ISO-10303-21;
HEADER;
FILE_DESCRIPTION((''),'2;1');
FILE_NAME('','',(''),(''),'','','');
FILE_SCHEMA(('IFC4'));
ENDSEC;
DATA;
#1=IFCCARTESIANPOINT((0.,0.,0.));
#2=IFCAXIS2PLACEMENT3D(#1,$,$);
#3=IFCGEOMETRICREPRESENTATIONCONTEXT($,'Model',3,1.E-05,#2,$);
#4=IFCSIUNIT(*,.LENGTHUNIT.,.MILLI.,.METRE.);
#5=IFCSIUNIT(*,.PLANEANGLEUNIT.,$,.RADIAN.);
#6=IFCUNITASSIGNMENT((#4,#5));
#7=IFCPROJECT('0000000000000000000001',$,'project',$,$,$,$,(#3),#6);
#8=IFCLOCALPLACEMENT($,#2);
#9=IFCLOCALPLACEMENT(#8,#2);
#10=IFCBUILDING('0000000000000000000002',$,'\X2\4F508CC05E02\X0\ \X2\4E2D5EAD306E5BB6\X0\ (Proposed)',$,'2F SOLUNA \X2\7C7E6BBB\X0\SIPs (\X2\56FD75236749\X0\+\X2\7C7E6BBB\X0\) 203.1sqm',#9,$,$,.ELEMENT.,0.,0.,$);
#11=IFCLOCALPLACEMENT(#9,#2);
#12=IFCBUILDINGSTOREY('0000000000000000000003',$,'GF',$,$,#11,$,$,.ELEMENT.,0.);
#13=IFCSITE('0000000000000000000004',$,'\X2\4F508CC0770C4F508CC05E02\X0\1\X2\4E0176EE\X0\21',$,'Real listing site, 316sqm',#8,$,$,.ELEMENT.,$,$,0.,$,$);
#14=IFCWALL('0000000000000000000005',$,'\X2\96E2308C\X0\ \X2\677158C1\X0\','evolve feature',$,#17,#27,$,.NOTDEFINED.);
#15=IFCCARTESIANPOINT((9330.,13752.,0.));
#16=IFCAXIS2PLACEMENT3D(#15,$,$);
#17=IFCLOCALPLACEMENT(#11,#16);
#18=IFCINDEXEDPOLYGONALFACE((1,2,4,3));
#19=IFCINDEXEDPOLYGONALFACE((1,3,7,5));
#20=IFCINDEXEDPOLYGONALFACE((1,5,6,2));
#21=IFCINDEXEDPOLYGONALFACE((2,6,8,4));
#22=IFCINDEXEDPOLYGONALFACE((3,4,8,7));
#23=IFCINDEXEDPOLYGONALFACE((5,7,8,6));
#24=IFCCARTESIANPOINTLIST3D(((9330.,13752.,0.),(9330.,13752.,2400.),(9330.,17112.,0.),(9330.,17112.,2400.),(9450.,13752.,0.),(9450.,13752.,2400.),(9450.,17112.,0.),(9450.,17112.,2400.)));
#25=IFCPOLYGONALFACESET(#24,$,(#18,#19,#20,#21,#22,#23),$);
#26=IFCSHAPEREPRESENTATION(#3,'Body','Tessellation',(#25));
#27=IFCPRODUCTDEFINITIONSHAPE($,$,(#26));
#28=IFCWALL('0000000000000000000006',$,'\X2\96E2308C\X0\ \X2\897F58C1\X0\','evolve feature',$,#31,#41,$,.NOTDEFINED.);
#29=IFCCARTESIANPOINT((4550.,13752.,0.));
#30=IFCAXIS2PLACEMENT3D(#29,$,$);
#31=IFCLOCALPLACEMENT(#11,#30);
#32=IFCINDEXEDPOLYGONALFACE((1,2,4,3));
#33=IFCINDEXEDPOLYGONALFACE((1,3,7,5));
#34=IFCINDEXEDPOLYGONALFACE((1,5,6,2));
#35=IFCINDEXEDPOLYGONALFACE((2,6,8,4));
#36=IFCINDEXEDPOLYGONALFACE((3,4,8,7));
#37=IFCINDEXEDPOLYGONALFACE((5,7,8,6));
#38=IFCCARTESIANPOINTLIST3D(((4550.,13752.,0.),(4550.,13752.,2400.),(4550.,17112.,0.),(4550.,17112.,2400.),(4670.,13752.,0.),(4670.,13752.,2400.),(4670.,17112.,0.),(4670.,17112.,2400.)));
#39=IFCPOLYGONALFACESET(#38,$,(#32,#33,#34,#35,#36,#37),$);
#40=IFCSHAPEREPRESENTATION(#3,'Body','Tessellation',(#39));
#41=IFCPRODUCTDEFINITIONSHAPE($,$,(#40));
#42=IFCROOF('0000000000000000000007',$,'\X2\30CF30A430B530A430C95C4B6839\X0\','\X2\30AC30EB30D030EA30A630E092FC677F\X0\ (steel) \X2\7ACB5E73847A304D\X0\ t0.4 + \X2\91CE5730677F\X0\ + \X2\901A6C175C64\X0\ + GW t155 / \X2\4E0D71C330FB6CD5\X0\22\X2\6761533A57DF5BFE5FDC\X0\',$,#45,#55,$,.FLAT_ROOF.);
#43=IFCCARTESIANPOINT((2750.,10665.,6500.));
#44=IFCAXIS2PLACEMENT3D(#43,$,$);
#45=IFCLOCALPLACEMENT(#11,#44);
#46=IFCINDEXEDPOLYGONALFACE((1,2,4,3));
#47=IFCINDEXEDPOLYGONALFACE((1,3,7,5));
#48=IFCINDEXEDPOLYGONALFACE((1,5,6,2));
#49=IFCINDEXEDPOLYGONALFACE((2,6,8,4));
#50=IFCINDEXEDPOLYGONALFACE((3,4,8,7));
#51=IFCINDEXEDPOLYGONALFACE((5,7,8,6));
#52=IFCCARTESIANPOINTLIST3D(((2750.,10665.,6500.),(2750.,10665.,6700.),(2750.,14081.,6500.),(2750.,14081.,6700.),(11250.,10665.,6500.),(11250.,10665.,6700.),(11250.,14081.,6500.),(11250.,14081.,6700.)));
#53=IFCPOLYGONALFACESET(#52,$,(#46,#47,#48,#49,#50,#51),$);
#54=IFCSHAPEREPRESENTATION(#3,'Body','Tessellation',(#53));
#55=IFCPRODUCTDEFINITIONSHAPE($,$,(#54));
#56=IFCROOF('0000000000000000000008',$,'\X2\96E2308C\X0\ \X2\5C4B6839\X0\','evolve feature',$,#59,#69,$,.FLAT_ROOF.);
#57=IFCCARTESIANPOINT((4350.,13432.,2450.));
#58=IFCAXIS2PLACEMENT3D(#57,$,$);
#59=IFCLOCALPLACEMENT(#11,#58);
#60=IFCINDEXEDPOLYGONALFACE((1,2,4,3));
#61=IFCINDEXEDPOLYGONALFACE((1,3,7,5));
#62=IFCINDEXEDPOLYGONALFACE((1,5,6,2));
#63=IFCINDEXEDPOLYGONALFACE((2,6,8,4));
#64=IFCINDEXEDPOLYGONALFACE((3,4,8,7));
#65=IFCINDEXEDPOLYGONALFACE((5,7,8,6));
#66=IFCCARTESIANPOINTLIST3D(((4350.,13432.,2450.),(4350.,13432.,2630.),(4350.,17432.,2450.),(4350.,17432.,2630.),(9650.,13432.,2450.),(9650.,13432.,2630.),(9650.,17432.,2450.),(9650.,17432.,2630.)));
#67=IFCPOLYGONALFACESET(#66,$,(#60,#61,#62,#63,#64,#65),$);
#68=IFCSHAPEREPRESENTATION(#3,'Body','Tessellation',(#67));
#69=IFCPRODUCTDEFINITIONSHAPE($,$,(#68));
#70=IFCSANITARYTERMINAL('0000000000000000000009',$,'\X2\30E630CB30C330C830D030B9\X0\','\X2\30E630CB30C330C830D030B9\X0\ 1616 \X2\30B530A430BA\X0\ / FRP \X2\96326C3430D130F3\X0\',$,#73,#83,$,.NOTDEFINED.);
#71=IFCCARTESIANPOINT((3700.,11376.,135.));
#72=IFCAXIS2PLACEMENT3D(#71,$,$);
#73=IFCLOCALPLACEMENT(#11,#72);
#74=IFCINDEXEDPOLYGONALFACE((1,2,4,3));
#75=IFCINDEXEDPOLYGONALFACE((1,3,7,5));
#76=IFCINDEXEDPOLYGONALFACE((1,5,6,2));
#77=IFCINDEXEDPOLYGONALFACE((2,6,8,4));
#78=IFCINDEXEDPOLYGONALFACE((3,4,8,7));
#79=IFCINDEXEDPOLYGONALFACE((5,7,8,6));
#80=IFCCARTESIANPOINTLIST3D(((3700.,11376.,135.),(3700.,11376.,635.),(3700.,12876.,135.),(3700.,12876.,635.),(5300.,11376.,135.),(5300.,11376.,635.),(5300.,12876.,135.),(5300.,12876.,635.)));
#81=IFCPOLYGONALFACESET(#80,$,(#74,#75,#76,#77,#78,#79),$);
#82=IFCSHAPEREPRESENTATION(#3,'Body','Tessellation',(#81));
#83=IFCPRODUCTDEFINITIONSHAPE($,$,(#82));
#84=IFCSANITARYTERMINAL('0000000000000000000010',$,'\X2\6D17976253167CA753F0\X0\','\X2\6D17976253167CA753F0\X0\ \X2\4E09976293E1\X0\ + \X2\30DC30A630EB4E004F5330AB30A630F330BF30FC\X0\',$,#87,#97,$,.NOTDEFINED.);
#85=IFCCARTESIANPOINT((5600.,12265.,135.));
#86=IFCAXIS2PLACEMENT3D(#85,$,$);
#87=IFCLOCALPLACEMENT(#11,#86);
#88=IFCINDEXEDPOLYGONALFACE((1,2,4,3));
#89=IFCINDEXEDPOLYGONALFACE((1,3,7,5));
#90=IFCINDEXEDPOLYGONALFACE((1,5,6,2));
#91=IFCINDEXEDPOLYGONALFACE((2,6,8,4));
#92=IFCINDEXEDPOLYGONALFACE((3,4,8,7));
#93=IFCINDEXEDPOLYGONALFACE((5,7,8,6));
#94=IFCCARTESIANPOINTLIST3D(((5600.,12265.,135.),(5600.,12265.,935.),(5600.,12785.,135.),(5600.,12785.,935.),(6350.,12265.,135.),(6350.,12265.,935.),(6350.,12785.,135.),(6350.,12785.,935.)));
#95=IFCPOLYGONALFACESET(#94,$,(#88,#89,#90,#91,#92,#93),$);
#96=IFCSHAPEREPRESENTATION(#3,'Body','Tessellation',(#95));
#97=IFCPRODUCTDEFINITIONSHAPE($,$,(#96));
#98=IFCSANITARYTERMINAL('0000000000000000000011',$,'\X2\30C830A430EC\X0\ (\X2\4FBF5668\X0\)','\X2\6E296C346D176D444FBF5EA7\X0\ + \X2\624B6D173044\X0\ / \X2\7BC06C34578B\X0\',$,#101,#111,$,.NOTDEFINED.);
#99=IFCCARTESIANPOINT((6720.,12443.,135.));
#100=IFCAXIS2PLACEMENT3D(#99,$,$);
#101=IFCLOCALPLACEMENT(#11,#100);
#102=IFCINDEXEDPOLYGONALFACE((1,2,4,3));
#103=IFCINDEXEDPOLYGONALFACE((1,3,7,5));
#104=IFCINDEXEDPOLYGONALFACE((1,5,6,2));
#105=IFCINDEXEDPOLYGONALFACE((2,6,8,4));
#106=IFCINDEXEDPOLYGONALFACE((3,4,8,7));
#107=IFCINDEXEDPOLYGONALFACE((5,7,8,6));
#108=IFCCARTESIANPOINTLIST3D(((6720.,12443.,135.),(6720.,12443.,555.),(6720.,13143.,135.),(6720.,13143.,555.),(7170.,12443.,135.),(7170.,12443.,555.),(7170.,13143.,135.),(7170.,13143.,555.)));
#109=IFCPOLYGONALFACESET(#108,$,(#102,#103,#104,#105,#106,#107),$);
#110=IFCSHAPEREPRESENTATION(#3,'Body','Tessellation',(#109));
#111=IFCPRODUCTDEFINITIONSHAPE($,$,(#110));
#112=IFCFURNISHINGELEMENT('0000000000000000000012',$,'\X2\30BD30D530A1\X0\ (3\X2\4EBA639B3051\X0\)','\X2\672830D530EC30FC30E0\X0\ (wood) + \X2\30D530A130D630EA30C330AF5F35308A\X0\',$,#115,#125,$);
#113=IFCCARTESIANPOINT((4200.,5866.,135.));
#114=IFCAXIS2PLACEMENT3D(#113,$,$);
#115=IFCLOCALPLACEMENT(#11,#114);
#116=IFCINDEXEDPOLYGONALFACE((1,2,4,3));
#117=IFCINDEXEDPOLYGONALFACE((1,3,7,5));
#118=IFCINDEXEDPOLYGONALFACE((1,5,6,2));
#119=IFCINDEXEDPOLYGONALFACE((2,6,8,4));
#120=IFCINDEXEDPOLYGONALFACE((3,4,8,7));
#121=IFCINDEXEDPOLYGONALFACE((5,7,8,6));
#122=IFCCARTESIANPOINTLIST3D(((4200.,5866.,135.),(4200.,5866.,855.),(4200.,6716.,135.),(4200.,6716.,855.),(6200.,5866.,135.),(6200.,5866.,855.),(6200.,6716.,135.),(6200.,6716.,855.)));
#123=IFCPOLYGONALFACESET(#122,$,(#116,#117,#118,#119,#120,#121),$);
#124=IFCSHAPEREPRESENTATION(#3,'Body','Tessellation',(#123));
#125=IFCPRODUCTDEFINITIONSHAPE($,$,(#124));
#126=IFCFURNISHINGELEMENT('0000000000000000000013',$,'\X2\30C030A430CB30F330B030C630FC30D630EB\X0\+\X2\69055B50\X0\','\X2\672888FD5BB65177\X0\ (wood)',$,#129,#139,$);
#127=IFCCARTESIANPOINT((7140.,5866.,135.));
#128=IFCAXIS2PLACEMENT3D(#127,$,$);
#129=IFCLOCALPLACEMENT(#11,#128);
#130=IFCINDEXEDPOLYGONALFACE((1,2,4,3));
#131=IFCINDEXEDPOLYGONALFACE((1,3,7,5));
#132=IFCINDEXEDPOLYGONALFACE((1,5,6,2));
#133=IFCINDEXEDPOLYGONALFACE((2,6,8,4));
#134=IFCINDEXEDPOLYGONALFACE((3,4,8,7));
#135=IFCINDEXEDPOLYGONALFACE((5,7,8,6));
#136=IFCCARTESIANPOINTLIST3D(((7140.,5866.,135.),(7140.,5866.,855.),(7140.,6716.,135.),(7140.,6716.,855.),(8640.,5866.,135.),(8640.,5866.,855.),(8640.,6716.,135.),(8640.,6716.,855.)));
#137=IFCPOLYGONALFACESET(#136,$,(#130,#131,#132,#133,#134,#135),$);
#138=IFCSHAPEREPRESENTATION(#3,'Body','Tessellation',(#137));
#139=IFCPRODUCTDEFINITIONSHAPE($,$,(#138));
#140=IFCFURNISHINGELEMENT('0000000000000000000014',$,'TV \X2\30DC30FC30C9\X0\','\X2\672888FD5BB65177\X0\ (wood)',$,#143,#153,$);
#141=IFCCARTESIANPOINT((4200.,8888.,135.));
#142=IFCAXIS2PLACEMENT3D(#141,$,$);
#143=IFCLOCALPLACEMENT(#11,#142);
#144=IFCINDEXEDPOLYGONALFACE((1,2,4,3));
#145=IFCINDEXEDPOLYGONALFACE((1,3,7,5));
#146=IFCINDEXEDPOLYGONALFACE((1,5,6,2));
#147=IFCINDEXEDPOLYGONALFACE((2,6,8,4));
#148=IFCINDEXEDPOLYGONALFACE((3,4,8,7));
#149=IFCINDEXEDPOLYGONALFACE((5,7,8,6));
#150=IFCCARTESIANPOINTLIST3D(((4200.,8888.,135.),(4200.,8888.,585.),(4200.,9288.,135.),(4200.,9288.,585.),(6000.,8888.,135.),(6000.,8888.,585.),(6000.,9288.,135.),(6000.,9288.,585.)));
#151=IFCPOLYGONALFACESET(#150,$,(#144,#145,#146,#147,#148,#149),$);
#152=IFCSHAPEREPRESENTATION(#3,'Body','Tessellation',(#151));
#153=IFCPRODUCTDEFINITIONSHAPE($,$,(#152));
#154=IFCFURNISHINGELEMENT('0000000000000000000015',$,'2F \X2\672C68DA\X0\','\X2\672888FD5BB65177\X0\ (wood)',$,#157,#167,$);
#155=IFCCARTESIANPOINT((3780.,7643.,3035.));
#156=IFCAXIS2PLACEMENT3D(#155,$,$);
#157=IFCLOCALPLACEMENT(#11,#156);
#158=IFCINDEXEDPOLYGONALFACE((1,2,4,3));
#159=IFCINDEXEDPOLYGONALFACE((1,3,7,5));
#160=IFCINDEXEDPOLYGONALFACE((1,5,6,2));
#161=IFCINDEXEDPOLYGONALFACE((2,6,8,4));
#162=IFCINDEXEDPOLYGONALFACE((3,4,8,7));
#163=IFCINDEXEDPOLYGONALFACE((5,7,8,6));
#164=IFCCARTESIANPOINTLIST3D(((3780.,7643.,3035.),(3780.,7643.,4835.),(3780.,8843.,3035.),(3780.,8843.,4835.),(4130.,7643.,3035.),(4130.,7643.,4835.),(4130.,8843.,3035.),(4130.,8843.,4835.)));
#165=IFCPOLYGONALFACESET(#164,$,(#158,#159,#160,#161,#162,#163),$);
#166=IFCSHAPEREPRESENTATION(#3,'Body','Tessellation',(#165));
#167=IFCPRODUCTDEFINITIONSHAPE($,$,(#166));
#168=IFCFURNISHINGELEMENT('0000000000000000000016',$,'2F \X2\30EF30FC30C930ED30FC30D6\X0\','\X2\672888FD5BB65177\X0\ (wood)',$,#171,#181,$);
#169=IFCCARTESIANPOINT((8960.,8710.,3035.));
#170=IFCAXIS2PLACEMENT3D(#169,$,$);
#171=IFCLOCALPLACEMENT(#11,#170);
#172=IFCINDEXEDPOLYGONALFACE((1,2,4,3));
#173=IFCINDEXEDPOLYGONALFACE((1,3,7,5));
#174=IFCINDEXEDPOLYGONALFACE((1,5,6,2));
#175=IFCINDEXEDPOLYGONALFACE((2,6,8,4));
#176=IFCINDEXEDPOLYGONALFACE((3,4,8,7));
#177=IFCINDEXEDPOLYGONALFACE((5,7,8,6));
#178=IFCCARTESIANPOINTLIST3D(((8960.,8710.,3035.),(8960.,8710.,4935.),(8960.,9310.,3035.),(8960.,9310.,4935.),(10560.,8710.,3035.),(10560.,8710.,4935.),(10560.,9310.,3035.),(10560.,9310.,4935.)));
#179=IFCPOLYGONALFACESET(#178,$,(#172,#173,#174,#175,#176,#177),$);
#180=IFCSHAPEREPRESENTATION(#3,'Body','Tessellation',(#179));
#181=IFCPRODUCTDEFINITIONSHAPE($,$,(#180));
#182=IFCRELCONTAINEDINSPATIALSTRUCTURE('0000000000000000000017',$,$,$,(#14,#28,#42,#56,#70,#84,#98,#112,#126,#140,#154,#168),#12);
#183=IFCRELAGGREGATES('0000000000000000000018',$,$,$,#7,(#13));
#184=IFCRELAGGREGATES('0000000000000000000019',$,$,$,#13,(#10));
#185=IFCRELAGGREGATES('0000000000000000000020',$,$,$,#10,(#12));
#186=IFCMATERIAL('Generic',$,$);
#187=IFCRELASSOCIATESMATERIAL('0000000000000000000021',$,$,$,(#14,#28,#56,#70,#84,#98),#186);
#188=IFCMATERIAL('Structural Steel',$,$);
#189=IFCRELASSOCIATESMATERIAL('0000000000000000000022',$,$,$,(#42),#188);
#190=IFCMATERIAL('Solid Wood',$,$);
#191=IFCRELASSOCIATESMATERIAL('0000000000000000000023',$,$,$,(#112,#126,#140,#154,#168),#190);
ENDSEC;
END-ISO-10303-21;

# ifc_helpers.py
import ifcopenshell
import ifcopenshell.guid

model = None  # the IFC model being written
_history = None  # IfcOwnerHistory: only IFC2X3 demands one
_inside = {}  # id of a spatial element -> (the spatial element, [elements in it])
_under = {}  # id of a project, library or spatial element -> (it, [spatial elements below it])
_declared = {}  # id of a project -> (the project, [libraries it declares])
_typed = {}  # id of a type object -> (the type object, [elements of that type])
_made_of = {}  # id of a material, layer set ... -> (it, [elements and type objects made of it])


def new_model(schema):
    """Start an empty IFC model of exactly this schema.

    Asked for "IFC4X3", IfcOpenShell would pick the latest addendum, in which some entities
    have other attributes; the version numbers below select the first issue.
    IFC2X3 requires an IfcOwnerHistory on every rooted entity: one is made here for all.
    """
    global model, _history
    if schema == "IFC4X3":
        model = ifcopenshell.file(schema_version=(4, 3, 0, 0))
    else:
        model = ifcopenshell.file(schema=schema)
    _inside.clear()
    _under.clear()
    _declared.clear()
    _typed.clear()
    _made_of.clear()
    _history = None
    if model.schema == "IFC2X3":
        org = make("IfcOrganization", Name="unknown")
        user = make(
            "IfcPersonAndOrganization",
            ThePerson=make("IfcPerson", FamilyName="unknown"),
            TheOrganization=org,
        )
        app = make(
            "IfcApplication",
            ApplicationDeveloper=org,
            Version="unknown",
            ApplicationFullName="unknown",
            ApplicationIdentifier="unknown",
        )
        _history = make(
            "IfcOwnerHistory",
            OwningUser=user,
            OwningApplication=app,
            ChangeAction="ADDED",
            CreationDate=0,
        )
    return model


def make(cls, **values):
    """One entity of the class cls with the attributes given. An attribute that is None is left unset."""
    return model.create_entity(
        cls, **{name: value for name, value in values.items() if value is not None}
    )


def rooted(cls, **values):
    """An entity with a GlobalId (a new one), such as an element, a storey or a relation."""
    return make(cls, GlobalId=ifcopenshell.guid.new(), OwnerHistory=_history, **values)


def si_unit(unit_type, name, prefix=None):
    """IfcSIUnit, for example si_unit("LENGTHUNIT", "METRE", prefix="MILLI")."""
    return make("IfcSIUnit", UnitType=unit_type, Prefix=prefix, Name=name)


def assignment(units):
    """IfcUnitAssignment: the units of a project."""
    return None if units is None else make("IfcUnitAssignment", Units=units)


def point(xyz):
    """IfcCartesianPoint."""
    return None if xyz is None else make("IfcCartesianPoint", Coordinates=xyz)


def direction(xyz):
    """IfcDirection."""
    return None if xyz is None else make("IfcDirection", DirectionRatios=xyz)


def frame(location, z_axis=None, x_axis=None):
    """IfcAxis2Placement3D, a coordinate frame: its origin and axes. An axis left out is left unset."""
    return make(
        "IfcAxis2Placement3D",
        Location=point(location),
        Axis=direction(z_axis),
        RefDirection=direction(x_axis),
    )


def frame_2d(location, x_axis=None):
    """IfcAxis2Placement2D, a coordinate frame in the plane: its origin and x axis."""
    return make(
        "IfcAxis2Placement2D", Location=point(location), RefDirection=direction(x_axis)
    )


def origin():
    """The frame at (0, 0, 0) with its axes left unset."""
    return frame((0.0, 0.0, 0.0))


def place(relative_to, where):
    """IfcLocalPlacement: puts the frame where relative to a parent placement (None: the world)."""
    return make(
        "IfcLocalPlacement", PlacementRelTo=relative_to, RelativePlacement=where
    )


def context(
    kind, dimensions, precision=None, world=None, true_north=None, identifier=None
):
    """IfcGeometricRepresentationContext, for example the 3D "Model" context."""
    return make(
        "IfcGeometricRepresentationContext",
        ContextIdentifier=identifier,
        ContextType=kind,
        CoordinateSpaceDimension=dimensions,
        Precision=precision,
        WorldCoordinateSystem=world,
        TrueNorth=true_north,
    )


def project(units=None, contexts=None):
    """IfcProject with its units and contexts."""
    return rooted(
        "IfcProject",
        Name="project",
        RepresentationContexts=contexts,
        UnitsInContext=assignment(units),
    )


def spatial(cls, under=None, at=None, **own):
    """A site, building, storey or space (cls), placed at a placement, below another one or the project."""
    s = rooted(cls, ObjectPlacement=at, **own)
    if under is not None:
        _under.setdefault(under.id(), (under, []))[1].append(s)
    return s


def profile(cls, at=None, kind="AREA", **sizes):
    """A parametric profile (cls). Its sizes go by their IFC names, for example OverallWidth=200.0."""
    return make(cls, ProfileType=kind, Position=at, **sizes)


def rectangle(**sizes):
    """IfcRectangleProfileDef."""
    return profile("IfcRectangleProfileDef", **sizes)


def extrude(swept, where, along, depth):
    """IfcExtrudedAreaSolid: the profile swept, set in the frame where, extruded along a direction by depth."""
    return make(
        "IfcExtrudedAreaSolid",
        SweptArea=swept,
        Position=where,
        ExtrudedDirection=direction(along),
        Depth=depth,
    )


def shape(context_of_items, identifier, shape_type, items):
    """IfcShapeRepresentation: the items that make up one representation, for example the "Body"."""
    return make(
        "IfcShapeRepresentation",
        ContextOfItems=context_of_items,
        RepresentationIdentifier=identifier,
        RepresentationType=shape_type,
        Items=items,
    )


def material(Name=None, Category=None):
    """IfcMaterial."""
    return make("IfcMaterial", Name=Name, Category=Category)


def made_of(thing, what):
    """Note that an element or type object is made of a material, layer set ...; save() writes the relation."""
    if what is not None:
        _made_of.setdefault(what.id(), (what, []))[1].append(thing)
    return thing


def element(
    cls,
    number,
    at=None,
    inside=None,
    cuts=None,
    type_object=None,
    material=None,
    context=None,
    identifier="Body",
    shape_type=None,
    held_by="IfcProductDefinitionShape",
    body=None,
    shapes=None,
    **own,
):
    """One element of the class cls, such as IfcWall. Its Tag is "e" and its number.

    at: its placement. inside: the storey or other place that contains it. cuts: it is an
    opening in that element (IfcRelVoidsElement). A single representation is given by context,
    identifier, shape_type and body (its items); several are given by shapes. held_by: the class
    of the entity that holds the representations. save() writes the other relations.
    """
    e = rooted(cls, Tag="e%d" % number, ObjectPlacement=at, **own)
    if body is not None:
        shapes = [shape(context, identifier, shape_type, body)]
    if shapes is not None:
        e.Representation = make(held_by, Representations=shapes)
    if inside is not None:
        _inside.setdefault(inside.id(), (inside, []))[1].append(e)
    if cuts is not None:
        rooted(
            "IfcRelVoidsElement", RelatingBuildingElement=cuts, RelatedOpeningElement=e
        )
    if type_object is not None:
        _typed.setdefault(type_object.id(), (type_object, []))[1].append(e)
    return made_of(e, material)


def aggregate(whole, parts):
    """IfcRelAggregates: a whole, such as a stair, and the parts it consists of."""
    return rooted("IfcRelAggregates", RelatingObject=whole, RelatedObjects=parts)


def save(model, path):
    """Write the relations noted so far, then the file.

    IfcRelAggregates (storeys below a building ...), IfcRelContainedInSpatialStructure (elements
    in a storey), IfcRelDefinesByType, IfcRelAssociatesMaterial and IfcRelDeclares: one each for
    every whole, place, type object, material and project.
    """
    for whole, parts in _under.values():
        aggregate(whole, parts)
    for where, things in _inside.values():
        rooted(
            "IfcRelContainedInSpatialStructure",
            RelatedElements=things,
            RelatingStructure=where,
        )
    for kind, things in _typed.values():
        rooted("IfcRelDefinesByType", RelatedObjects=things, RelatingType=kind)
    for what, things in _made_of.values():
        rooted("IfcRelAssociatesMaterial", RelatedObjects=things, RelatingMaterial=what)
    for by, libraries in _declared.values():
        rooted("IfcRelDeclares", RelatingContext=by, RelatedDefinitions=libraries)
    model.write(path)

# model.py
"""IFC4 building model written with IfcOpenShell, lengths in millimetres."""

from ifc_helpers import new_model, si_unit, frame, frame_2d, origin, place, context, project, spatial, rectangle, extrude, material, element, save


model = new_model("IFC4")

# Units and contexts
model_context = context("Model", 3, precision=1e-05, world=origin())
ifc_project = project(units=[si_unit("LENGTHUNIT", "METRE", prefix="MILLI"), si_unit("PLANEANGLEUNIT", "RADIAN")], contexts=[model_context])

# Site, building, storey
site_placement = place(None, origin())
site = spatial("IfcSite", under=ifc_project, at=site_placement, Name="佐賀県佐賀市1丁目21", ObjectType="Real listing site, 316sqm", CompositionType="ELEMENT", RefElevation=0.0)
building_placement = place(site_placement, origin())
building = spatial("IfcBuilding", under=site, at=building_placement, Name="佐賀市 中庭の家 (Proposed)", ObjectType="2F SOLUNA 籾殻SIPs (国産杉+籾殻) 203.1sqm", CompositionType="ELEMENT", ElevationOfRefHeight=0.0, ElevationOfTerrain=0.0)
storey_placement = place(building_placement, origin())
storey = spatial("IfcBuildingStorey", under=building, at=storey_placement, Name="GF", CompositionType="ELEMENT", Elevation=0.0)

# Shared definitions
ifc_material_1 = material(Name="Generic")

# Shared definitions
ifc_material_2 = material(Name="Solid Wood")

# Walls
wall_1_placement = place(storey_placement, frame((9330.0, 13752.0, 0.0)))
element("IfcWall", 1, at=wall_1_placement, inside=storey, material=ifc_material_1, Name="離れ 東壁", Description="evolve feature", PredefinedType="NOTDEFINED", context=model_context, shape_type="SweptSolid", body=[
    extrude(rectangle(XDim=120.0, YDim=3360.0, at=frame_2d((60.0, 1680.0))), frame((9330.0, 13752.0, 0.0)), (0.0, 0.0, 1.0), 2400.0),
])
wall_2_placement = place(storey_placement, frame((4550.0, 13752.0, 0.0)))
element("IfcWall", 2, at=wall_2_placement, inside=storey, material=ifc_material_1, Name="離れ 西壁", Description="evolve feature", PredefinedType="NOTDEFINED", context=model_context, shape_type="SweptSolid", body=[
    extrude(rectangle(XDim=120.0, YDim=3360.0, at=frame_2d((60.0, 1680.0))), frame((4550.0, 13752.0, 0.0)), (0.0, 0.0, 1.0), 2400.0),
])

# Roofs
ifc_material_3 = material(Name="Structural Steel")
roof_1_placement = place(storey_placement, frame((2750.0, 10665.0, 6500.0)))
element("IfcRoof", 3, at=roof_1_placement, inside=storey, material=ifc_material_3, Name="ハイサイド屋根", Description="ガルバリウム鋼板 (steel) 立平葺き t0.4 + 野地板 + 通気層 + GW t155 / 不燃・法22条区域対応", PredefinedType="FLAT_ROOF", context=model_context, shape_type="SweptSolid", body=[
    extrude(rectangle(XDim=8500.0, YDim=3416.0, at=frame_2d((4250.0, 1708.0))), frame((2750.0, 10665.0, 6500.0)), (0.0, 0.0, 1.0), 200.0),
])
roof_2_placement = place(storey_placement, frame((4350.0, 13432.0, 2450.0)))
element("IfcRoof", 4, at=roof_2_placement, inside=storey, material=ifc_material_1, Name="離れ 屋根", Description="evolve feature", PredefinedType="FLAT_ROOF", context=model_context, shape_type="SweptSolid", body=[
    extrude(rectangle(XDim=5300.0, YDim=4000.0, at=frame_2d((2650.0, 2000.0))), frame((4350.0, 13432.0, 2450.0)), (0.0, 0.0, 1.0), 180.0),
])

# Sanitary terminals
sanitary_terminal_1_placement = place(storey_placement, frame((3700.0, 11376.0, 135.0)))
element("IfcSanitaryTerminal", 5, at=sanitary_terminal_1_placement, inside=storey, material=ifc_material_1, Name="ユニットバス", Description="ユニットバス 1616 サイズ / FRP 防水パン", PredefinedType="NOTDEFINED", context=model_context, shape_type="SweptSolid", body=[
    extrude(rectangle(XDim=1600.0, YDim=1500.0, at=frame_2d((800.0, 750.0))), frame((3700.0, 11376.0, 135.0)), (0.0, 0.0, 1.0), 500.0),
])
sanitary_terminal_2_placement = place(storey_placement, frame((5600.0, 12265.0, 135.0)))
element("IfcSanitaryTerminal", 6, at=sanitary_terminal_2_placement, inside=storey, material=ifc_material_1, Name="洗面化粧台", Description="洗面化粧台 三面鏡 + ボウル一体カウンター", PredefinedType="NOTDEFINED", context=model_context, shape_type="SweptSolid", body=[
    extrude(rectangle(XDim=750.0, YDim=520.0, at=frame_2d((375.0, 260.0))), frame((5600.0, 12265.0, 135.0)), (0.0, 0.0, 1.0), 800.0),
])
sanitary_terminal_3_placement = place(storey_placement, frame((6720.0, 12443.0, 135.0)))
element("IfcSanitaryTerminal", 7, at=sanitary_terminal_3_placement, inside=storey, material=ifc_material_1, Name="トイレ (便器)", Description="温水洗浄便座 + 手洗い / 節水型", PredefinedType="NOTDEFINED", context=model_context, shape_type="SweptSolid", body=[
    extrude(rectangle(XDim=450.0, YDim=700.0, at=frame_2d((225.0, 350.0))), frame((6720.0, 12443.0, 135.0)), (0.0, 0.0, 1.0), 420.0),
])

# Furnishing elements
furnishing_1_placement = place(storey_placement, frame((4200.0, 5866.0, 135.0)))
element("IfcFurnishingElement", 8, at=furnishing_1_placement, inside=storey, material=ifc_material_2, Name="ソファ (3人掛け)", Description="木フレーム (wood) + ファブリック張り", context=model_context, shape_type="SweptSolid", body=[
    extrude(rectangle(XDim=2000.0, YDim=850.0, at=frame_2d((1000.0, 425.0))), frame((4200.0, 5866.0, 135.0)), (0.0, 0.0, 1.0), 720.0),
])
furnishing_2_placement = place(storey_placement, frame((7140.0, 5866.0, 135.0)))
element("IfcFurnishingElement", 9, at=furnishing_2_placement, inside=storey, material=ifc_material_2, Name="ダイニングテーブル+椅子", Description="木製家具 (wood)", context=model_context, shape_type="SweptSolid", body=[
    extrude(rectangle(XDim=1500.0, YDim=850.0, at=frame_2d((750.0, 425.0))), frame((7140.0, 5866.0, 135.0)), (0.0, 0.0, 1.0), 720.0),
])
furnishing_3_placement = place(storey_placement, frame((4200.0, 8888.0, 135.0)))
element("IfcFurnishingElement", 10, at=furnishing_3_placement, inside=storey, material=ifc_material_2, Name="TV ボード", Description="木製家具 (wood)", context=model_context, shape_type="SweptSolid", body=[
    extrude(rectangle(XDim=1800.0, YDim=400.0, at=frame_2d((900.0, 200.0))), frame((4200.0, 8888.0, 135.0)), (0.0, 0.0, 1.0), 450.0),
])
furnishing_4_placement = place(storey_placement, frame((3780.0, 7643.0, 3035.0)))
element("IfcFurnishingElement", 11, at=furnishing_4_placement, inside=storey, material=ifc_material_2, Name="2F 本棚", Description="木製家具 (wood)", context=model_context, shape_type="SweptSolid", body=[
    extrude(rectangle(XDim=350.0, YDim=1200.0, at=frame_2d((175.0, 600.0))), frame((3780.0, 7643.0, 3035.0)), (0.0, 0.0, 1.0), 1800.0),
])
furnishing_5_placement = place(storey_placement, frame((8960.0, 8710.0, 3035.0)))
element("IfcFurnishingElement", 12, at=furnishing_5_placement, inside=storey, material=ifc_material_2, Name="2F ワードローブ", Description="木製家具 (wood)", context=model_context, shape_type="SweptSolid", body=[
    extrude(rectangle(XDim=1600.0, YDim=600.0, at=frame_2d((800.0, 300.0))), frame((8960.0, 8710.0, 3035.0)), (0.0, 0.0, 1.0), 1900.0),
])

save(model, "model.ifc")
